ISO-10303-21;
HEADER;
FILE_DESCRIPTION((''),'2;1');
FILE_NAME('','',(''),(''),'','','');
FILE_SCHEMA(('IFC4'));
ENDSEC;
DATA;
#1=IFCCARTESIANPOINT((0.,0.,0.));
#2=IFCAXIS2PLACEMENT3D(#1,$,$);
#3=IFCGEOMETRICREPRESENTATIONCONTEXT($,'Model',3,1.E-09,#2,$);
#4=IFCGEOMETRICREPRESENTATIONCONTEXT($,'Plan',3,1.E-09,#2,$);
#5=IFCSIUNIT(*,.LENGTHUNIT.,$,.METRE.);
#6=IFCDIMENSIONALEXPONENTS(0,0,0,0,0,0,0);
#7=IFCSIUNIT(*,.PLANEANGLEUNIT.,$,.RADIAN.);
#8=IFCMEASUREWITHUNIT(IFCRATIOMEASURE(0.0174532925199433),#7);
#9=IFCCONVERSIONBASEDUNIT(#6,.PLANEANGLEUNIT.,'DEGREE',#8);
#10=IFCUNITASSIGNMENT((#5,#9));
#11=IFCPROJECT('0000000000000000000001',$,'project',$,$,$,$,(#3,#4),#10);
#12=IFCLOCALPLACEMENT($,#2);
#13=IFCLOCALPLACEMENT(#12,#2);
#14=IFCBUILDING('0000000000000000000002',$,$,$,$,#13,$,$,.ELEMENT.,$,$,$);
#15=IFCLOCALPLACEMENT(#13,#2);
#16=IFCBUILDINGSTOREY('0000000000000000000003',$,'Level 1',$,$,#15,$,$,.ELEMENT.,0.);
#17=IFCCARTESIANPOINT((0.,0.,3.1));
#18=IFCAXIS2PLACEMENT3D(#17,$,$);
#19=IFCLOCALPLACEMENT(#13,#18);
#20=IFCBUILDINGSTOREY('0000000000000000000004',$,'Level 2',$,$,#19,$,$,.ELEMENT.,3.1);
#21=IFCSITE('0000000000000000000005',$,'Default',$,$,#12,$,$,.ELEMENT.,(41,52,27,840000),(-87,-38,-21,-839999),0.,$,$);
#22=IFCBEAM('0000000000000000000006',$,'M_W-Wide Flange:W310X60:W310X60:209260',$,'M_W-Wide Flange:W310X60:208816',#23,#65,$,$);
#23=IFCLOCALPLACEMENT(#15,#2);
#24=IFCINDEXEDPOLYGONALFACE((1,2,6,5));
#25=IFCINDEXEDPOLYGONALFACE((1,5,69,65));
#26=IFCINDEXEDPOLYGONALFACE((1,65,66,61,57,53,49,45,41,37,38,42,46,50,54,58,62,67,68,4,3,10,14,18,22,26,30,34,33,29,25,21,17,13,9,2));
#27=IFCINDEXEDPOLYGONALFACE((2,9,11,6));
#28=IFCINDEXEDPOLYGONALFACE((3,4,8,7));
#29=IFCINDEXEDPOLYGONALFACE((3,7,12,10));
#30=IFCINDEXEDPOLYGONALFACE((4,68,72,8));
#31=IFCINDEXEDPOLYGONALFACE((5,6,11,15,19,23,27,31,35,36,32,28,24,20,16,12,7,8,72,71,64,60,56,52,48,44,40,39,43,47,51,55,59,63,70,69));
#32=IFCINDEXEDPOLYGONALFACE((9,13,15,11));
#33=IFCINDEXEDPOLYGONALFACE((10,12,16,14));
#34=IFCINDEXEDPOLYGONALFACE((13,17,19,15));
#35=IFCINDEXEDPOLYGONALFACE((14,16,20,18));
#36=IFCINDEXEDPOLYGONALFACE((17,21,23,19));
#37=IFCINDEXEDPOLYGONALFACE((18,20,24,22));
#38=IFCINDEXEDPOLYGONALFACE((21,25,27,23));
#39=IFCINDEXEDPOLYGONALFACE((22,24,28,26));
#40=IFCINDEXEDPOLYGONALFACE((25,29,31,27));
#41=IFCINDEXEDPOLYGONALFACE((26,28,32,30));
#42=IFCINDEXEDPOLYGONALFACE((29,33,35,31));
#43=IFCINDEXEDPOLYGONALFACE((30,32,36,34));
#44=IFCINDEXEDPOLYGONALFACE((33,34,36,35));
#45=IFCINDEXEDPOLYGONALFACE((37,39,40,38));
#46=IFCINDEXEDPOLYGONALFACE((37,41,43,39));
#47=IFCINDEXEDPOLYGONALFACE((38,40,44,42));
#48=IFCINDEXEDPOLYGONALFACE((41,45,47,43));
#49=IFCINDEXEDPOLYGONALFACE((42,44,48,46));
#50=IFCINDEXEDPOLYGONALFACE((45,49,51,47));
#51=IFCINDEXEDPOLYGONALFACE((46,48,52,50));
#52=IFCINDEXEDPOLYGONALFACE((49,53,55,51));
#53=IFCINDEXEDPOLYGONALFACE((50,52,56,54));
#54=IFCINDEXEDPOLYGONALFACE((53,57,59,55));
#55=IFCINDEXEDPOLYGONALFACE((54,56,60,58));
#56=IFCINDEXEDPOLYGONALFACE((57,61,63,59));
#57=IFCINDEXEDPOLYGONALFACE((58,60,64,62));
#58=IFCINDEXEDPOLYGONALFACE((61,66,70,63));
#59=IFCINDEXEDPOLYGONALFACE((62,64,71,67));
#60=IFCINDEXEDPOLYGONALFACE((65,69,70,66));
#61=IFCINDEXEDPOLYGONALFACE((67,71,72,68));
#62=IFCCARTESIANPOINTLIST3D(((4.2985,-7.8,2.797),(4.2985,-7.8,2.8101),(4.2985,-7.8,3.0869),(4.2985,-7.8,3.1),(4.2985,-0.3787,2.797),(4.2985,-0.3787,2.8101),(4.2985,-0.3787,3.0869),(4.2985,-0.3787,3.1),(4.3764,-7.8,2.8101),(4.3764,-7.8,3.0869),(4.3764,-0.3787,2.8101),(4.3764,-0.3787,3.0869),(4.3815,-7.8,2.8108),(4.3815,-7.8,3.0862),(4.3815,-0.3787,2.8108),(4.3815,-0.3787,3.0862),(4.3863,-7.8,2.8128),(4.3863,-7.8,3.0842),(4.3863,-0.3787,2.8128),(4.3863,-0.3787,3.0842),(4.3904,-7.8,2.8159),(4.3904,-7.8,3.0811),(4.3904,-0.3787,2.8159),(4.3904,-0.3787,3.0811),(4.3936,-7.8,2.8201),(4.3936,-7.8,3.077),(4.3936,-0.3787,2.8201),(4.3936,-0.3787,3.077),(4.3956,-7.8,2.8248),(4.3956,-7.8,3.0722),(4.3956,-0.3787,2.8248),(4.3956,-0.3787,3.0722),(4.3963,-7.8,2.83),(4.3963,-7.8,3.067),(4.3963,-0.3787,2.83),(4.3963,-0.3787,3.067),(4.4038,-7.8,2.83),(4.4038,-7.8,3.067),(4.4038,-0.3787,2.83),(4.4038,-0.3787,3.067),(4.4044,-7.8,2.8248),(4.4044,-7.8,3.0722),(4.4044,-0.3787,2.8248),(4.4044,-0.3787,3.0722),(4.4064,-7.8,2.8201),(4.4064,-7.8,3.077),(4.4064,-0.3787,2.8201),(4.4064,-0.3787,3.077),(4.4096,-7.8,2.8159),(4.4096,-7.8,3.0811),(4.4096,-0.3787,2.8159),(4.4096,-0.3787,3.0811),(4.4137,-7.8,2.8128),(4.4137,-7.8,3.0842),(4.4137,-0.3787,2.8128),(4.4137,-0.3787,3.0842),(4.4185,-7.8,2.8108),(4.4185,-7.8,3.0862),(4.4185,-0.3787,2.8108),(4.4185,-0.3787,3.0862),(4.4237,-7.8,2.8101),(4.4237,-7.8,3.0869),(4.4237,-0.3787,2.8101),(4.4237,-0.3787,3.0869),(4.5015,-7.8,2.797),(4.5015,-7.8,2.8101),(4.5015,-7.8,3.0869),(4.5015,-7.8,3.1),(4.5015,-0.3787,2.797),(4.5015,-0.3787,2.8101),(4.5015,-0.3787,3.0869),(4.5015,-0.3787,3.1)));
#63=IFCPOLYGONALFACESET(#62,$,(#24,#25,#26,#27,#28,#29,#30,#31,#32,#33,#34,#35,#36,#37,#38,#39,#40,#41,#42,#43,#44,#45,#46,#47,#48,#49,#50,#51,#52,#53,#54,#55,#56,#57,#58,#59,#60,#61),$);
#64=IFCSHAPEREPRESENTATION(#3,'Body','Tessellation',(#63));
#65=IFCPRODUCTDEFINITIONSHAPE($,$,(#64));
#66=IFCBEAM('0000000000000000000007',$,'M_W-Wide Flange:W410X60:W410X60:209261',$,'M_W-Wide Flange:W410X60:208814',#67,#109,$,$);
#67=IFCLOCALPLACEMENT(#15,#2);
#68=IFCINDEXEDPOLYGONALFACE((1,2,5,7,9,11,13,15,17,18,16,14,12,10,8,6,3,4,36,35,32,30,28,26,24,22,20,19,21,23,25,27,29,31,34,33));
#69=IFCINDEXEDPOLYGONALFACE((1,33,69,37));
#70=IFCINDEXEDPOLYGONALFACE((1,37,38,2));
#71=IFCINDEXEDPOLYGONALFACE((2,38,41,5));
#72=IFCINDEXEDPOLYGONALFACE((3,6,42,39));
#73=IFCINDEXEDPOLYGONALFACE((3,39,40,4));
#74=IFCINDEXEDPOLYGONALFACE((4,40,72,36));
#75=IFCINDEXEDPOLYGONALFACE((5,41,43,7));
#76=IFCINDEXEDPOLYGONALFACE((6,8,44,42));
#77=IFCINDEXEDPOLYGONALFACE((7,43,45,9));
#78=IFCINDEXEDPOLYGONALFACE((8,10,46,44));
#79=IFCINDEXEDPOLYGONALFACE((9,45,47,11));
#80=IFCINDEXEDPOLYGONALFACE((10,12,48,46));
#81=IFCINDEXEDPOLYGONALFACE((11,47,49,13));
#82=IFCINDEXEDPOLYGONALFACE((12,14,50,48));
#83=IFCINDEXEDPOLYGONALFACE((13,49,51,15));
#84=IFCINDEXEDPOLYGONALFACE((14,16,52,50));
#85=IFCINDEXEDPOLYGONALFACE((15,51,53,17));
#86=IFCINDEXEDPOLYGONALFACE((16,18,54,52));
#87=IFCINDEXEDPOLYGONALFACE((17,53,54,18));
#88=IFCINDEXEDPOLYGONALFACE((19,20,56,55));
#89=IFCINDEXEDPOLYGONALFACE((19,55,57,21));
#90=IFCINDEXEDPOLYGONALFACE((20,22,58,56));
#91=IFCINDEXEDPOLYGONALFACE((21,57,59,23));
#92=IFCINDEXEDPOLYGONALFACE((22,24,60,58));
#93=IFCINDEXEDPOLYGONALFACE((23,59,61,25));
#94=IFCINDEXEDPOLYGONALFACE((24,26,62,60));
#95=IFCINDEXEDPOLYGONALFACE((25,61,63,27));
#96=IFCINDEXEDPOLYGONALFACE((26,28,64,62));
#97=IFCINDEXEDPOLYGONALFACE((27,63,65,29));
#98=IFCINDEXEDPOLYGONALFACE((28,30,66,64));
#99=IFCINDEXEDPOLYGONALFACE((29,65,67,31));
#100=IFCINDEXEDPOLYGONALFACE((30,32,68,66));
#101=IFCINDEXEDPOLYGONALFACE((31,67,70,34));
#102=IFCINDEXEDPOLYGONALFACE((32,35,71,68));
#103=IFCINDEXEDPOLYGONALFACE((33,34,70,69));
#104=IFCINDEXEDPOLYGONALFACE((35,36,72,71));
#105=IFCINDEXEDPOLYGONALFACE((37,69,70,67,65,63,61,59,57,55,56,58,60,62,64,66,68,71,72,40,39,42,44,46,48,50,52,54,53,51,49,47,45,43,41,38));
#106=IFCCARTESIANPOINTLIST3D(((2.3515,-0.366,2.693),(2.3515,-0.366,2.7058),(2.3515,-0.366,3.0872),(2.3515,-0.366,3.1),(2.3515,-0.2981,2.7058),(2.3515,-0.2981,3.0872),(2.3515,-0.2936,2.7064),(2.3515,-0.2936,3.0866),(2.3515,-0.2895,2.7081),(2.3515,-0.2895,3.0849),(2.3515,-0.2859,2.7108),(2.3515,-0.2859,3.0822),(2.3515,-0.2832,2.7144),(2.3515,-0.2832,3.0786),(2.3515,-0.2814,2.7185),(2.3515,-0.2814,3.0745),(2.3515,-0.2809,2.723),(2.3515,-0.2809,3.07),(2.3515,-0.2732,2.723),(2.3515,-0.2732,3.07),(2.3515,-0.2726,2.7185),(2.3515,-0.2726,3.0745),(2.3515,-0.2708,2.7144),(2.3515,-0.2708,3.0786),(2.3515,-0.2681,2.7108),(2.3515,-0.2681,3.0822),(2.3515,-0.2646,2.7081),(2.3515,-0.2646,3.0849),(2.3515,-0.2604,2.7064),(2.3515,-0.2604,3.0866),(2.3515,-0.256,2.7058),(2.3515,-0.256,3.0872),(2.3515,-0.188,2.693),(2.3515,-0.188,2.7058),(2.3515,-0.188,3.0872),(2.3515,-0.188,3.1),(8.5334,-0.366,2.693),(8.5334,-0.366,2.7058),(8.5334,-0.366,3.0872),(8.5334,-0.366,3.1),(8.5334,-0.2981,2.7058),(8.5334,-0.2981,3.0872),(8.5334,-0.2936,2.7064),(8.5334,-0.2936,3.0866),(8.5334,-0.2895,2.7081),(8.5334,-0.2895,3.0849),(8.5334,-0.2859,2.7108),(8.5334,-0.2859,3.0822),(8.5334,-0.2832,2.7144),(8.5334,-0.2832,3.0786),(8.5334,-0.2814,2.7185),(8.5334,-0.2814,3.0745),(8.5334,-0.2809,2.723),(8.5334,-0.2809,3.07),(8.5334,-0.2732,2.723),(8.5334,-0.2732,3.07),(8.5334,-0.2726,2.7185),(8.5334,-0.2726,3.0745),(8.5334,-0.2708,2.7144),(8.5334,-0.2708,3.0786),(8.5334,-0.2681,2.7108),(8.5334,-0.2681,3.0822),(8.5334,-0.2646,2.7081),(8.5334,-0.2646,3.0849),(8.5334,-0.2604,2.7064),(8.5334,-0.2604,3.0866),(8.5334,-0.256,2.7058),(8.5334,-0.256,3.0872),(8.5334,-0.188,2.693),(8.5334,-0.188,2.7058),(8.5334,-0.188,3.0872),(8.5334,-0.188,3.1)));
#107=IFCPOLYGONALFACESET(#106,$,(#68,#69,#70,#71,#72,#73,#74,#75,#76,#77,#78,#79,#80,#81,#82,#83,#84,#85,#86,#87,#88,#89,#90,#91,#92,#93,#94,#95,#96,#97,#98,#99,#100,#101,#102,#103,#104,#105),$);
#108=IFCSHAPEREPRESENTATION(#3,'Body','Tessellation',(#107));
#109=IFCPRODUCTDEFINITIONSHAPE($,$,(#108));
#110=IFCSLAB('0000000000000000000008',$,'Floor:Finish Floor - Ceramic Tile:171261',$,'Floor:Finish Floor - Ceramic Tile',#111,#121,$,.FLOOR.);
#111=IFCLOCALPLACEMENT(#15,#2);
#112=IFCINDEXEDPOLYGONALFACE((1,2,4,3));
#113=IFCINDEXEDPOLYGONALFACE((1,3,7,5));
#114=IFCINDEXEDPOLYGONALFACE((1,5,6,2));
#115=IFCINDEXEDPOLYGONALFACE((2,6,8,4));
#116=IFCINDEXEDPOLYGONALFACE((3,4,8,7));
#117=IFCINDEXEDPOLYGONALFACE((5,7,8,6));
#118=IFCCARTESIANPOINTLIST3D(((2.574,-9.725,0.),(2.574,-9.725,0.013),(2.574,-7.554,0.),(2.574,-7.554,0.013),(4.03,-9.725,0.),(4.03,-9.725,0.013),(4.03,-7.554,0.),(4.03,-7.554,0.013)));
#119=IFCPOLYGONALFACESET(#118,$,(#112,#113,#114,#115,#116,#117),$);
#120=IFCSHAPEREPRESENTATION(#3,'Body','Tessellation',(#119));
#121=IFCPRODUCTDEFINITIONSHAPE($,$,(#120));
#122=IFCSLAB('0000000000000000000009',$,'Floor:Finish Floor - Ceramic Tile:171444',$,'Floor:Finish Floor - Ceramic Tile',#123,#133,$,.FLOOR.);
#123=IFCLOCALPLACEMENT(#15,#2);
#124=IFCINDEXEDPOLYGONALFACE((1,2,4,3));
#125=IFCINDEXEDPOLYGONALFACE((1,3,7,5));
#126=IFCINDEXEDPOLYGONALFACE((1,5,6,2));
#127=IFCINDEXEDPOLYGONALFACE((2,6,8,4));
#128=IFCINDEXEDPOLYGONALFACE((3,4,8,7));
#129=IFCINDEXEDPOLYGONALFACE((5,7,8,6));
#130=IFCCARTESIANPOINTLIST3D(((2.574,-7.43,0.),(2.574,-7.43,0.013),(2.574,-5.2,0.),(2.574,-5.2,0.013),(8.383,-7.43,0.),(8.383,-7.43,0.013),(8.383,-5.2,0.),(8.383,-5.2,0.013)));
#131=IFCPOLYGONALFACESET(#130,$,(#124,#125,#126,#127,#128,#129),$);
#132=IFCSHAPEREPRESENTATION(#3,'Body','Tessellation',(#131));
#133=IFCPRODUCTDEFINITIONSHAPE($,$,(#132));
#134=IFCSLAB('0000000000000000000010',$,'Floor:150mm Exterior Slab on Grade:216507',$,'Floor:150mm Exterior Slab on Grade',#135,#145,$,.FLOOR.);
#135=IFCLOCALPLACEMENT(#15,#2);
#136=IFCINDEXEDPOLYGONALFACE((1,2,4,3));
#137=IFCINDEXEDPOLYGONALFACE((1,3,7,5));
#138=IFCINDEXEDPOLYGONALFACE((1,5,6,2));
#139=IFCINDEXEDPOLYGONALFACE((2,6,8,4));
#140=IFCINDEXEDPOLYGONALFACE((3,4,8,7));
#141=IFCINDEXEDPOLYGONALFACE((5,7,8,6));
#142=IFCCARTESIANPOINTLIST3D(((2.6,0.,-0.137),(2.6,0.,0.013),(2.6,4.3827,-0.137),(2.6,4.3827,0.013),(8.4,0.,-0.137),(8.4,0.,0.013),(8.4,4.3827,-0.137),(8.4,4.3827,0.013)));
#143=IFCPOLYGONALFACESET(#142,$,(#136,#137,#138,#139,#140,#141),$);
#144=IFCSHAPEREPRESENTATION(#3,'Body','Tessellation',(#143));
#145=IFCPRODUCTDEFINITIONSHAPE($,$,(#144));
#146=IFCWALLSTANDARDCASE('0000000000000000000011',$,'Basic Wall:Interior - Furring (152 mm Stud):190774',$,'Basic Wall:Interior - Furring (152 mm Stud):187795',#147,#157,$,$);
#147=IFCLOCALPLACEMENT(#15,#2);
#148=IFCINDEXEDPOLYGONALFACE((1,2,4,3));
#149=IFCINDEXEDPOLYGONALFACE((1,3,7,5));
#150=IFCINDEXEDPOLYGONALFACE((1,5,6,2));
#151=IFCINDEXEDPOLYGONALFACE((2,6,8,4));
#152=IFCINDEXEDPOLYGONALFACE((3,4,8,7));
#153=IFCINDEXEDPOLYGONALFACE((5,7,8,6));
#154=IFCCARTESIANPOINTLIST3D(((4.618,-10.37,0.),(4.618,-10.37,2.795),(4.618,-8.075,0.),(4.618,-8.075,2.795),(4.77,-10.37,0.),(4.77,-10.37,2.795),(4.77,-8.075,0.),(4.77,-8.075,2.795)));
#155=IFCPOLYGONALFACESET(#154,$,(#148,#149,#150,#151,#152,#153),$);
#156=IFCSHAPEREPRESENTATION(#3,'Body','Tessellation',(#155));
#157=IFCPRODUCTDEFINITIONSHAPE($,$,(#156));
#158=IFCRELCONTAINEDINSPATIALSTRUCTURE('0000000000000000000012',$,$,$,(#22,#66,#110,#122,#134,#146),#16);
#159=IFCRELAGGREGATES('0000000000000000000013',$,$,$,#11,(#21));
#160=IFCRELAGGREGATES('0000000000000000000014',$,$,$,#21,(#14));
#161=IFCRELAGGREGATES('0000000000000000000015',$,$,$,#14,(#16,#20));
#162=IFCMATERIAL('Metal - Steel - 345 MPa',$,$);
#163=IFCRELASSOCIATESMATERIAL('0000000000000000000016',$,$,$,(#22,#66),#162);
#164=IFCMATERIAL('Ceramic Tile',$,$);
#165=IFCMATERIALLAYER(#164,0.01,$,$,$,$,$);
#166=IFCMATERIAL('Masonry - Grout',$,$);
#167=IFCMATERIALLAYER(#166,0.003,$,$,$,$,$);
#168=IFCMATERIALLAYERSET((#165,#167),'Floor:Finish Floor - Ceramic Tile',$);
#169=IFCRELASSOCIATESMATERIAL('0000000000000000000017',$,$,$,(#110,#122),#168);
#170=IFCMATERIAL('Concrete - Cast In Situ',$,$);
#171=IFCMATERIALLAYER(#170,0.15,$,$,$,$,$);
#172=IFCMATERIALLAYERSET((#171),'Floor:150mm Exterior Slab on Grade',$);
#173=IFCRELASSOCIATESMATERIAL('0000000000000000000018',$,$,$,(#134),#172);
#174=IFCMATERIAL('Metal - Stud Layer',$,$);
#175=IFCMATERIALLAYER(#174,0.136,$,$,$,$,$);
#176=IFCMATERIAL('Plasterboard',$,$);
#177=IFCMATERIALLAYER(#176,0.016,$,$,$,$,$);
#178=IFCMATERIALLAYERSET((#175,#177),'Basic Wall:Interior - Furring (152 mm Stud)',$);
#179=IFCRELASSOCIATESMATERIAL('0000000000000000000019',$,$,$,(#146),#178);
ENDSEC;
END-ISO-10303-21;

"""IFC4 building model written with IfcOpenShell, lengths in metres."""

from ifc_helpers import new_model, entity, si_unit, converted_unit, frame, frame_2d, origin, place, context, project, spatial, polyline, circle_curve, parameter, trimmed, segment, composite_curve, rectangle, outline, extrude, material, layer, layer_set, layer_usage, element, save


model = new_model("IFC4")

# Units and contexts
model_context = context("Model", 3, precision=1e-09, world=origin())
plan_context = context("Plan", 3, precision=1e-09, world=origin())
ifc_project = project(units=[si_unit("LENGTHUNIT", "METRE"), converted_unit("PLANEANGLEUNIT", "DEGREE", entity("IfcRatioMeasure", 0.0174532925199433), si_unit("PLANEANGLEUNIT", "RADIAN"), dimensions=[0, 0, 0, 0, 0, 0, 0])], contexts=[model_context, plan_context])

# Site, building, storey
site_placement = place(None, origin())
site = spatial("IfcSite", under=ifc_project, at=site_placement, Name="Default", CompositionType="ELEMENT", RefLatitude=(41, 52, 27, 840000), RefLongitude=(-87, -38, -21, -839999), RefElevation=0.0)
building_placement = place(site_placement, origin())
building = spatial("IfcBuilding", under=site, at=building_placement, CompositionType="ELEMENT")
storey_1_placement = place(building_placement, origin())
storey_1 = spatial("IfcBuildingStorey", under=building, at=storey_1_placement, Name="Level 1", CompositionType="ELEMENT", Elevation=0.0)

# Beams
ifc_material_1 = material(Name="Metal - Steel - 345 MPa")
beam_1_placement = place(storey_1_placement, frame((4.4, -7.8, 3.1)))
element("IfcBeam", 1, at=beam_1_placement, inside=storey_1, material=ifc_material_1, Name="M_W-Wide Flange:W310X60:W310X60:209260", ObjectType="M_W-Wide Flange:W310X60:208816", context=model_context, shape_type="SweptSolid", body=[
    extrude(outline(composite_curve([segment(polyline([(-0.1015, -0.1384), (-0.1015, -0.1515)]), True, "CONTINUOUS"), segment(polyline([(-0.1015, -0.1515), (0.1015, -0.1515)]), True, "CONTINUOUS"), segment(polyline([(0.1015, -0.1515), (0.1015, -0.1384)]), True, "CONTINUOUS"), segment(polyline([(0.1015, -0.1384), (0.0236, -0.1384)]), True, "CONTINUOUS"), segment(trimmed(circle_curve(frame_2d((0.0236, -0.1185), x_axis=(1.0, 0.0)), 0.0199), [parameter(180.0)], [parameter(270.0)], True, "PARAMETER"), False, "CONTINUOUS"), segment(polyline([(0.0037, -0.1185), (0.0037, 0.1185)]), True, "CONTINUOUS"), segment(trimmed(circle_curve(frame_2d((0.0236, 0.1185), x_axis=(1.0, 0.0)), 0.0199), [parameter(90.0)], [parameter(180.0)], True, "PARAMETER"), False, "CONTINUOUS"), segment(polyline([(0.0236, 0.1384), (0.1015, 0.1384)]), True, "CONTINUOUS"), segment(polyline([(0.1015, 0.1384), (0.1015, 0.1515)]), True, "CONTINUOUS"), segment(polyline([(0.1015, 0.1515), (-0.1015, 0.1515)]), True, "CONTINUOUS"), segment(polyline([(-0.1015, 0.1515), (-0.1015, 0.1384)]), True, "CONTINUOUS"), segment(polyline([(-0.1015, 0.1384), (-0.0237, 0.1384)]), True, "CONTINUOUS"), segment(trimmed(circle_curve(frame_2d((-0.0237, 0.1185), x_axis=(1.0, 0.0)), 0.0199), [parameter(360.0)], [parameter(90.0)], True, "PARAMETER"), False, "CONTINUOUS"), segment(polyline([(-0.0038, 0.1185), (-0.0038, -0.1185)]), True, "CONTINUOUS"), segment(trimmed(circle_curve(frame_2d((-0.0237, -0.1185), x_axis=(1.0, 0.0)), 0.0199), [parameter(270.0)], [parameter(0.0)], True, "PARAMETER"), False, "CONTINUOUS"), segment(polyline([(-0.0237, -0.1384), (-0.1015, -0.1384)]), True, "CONTINUOUS")], self_intersect=False)), frame((0.0, 0.0, -0.1515), z_axis=(0.0, -1.0, 0.0), x_axis=(1.0, 0.0, 0.0)), (0.0, 0.0, -1.0), 7.4213),
])
beam_2_placement = place(storey_1_placement, frame((8.5915, -0.277, 3.1), z_axis=(0.0, 0.0, 1.0), x_axis=(0.0, 1.0, 0.0)))
element("IfcBeam", 2, at=beam_2_placement, inside=storey_1, material=ifc_material_1, Name="M_W-Wide Flange:W410X60:W410X60:209261", ObjectType="M_W-Wide Flange:W410X60:208814", context=model_context, shape_type="SweptSolid", body=[
    extrude(outline(composite_curve([segment(polyline([(0.1907, -0.089), (0.2035, -0.089)]), True, "CONTINUOUS"), segment(polyline([(0.2035, -0.089), (0.2035, 0.089)]), True, "CONTINUOUS"), segment(polyline([(0.2035, 0.089), (0.1907, 0.089)]), True, "CONTINUOUS"), segment(polyline([(0.1907, 0.089), (0.1907, 0.021)]), True, "CONTINUOUS"), segment(trimmed(circle_curve(frame_2d((0.1735, 0.021), x_axis=(1.0, 0.0)), 0.0172), [parameter(270.0)], [parameter(360.0)], True, "PARAMETER"), False, "CONTINUOUS"), segment(polyline([(0.1735, 0.0038), (-0.1735, 0.0038)]), True, "CONTINUOUS"), segment(trimmed(circle_curve(frame_2d((-0.1735, 0.021), x_axis=(0.0, -1.0)), 0.0172), [parameter(270.0)], [parameter(360.0)], True, "PARAMETER"), False, "CONTINUOUS"), segment(polyline([(-0.1907, 0.021), (-0.1907, 0.089)]), True, "CONTINUOUS"), segment(polyline([(-0.1907, 0.089), (-0.2035, 0.089)]), True, "CONTINUOUS"), segment(polyline([(-0.2035, 0.089), (-0.2035, -0.089)]), True, "CONTINUOUS"), segment(polyline([(-0.2035, -0.089), (-0.1907, -0.089)]), True, "CONTINUOUS"), segment(polyline([(-0.1907, -0.089), (-0.1907, -0.0211)]), True, "CONTINUOUS"), segment(trimmed(circle_curve(frame_2d((-0.1735, -0.0211), x_axis=(-1.0, 0.0)), 0.0172), [parameter(270.0)], [parameter(0.0)], True, "PARAMETER"), False, "CONTINUOUS"), segment(polyline([(-0.1735, -0.0039), (0.1735, -0.0039)]), True, "CONTINUOUS"), segment(trimmed(circle_curve(frame_2d((0.1735, -0.0211), x_axis=(0.0, 1.0)), 0.0172), [parameter(270.0)], [parameter(0.0)], True, "PARAMETER"), False, "CONTINUOUS"), segment(polyline([(0.1907, -0.0211), (0.1907, -0.089)]), True, "CONTINUOUS")], self_intersect=False)), frame((0.0, 6.24, -0.2035), z_axis=(0.0, -1.0, 0.0), x_axis=(0.0, 0.0, -1.0)), (0.0, 0.0, 1.0), 6.1819),
])

# Slabs
ifc_material_2 = material(Name="Ceramic Tile")
ifc_layer_1 = layer(ifc_material_2, 0.01)
ifc_material_3 = material(Name="Masonry - Grout")
ifc_layer_2 = layer(ifc_material_3, 0.003)
ifc_layer_set_1 = layer_set([ifc_layer_1, ifc_layer_2], Name="Floor:Finish Floor - Ceramic Tile")
ifc_layer_usage_1 = layer_usage(ifc_layer_set_1, "AXIS3", "POSITIVE", 0.0)
slab_1_placement = place(storey_1_placement, frame((2.574, -9.725, 0.0)))
element("IfcSlab", 3, at=slab_1_placement, inside=storey_1, material=ifc_layer_usage_1, Name="Floor:Finish Floor - Ceramic Tile:171261", ObjectType="Floor:Finish Floor - Ceramic Tile", PredefinedType="FLOOR", context=model_context, shape_type="SweptSolid", body=[
    extrude(rectangle(XDim=2.171, YDim=1.456, at=frame_2d((0.0, 0.0), x_axis=(0.0, -1.0))), frame((0.728, 1.0855, 0.013), z_axis=(0.0, 0.0, -1.0), x_axis=(-1.0, 0.0, 0.0)), (0.0, 0.0, 1.0), 0.013),
])
ifc_layer_usage_2 = layer_usage(ifc_layer_set_1, "AXIS3", "POSITIVE", 0.0)
slab_2_placement = place(storey_1_placement, frame((2.574, -7.43, 0.0)))
element("IfcSlab", 4, at=slab_2_placement, inside=storey_1, material=ifc_layer_usage_2, Name="Floor:Finish Floor - Ceramic Tile:171444", ObjectType="Floor:Finish Floor - Ceramic Tile", PredefinedType="FLOOR", context=model_context, shape_type="SweptSolid", body=[
    extrude(rectangle(XDim=5.809, YDim=2.23, at=frame_2d((0.0, 0.0), x_axis=(-1.0, 0.0))), frame((2.9045, 1.115, 0.013), z_axis=(0.0, 0.0, -1.0), x_axis=(-1.0, 0.0, 0.0)), (0.0, 0.0, 1.0), 0.013),
])
ifc_material_4 = material(Name="Concrete - Cast In Situ")
ifc_layer_3 = layer(ifc_material_4, 0.15)
ifc_layer_set_2 = layer_set([ifc_layer_3], Name="Floor:150mm Exterior Slab on Grade")
ifc_layer_usage_3 = layer_usage(ifc_layer_set_2, "AXIS3", "POSITIVE", 0.0)
slab_3_placement = place(storey_1_placement, frame((2.6, 0.0, -0.137)))
element("IfcSlab", 5, at=slab_3_placement, inside=storey_1, material=ifc_layer_usage_3, Name="Floor:150mm Exterior Slab on Grade:216507", ObjectType="Floor:150mm Exterior Slab on Grade", PredefinedType="FLOOR", context=model_context, shape_type="SweptSolid", body=[
    extrude(rectangle(XDim=5.8, YDim=4.3827, at=frame_2d((0.0, 0.0), x_axis=(-1.0, 0.0))), frame((2.9, 2.1914, 0.15), z_axis=(0.0, 0.0, -1.0), x_axis=(-1.0, 0.0, 0.0)), (0.0, 0.0, 1.0), 0.15),
])

# Wall
ifc_material_5 = material(Name="Metal - Stud Layer")
ifc_layer_4 = layer(ifc_material_5, 0.136)
ifc_material_6 = material(Name="Plasterboard")
ifc_layer_5 = layer(ifc_material_6, 0.016)
ifc_layer_set_3 = layer_set([ifc_layer_4, ifc_layer_5], Name="Basic Wall:Interior - Furring (152 mm Stud)")
ifc_layer_usage_4 = layer_usage(ifc_layer_set_3, "AXIS2", "POSITIVE", -0.076)
wall_1_placement = place(storey_1_placement, frame((4.694, -8.075, 0.0), z_axis=(0.0, 0.0, 1.0), x_axis=(0.0, -1.0, 0.0)))
element("IfcWallStandardCase", 6, at=wall_1_placement, inside=storey_1, material=ifc_layer_usage_4, Name="Basic Wall:Interior - Furring (152 mm Stud):190774", ObjectType="Basic Wall:Interior - Furring (152 mm Stud):187795", context=model_context, shape_type="SweptSolid", body=[
    extrude(rectangle(XDim=2.295, YDim=0.152, at=frame_2d((1.1475, 0.0), x_axis=(-1.0, 0.0))), origin(), (0.0, 0.0, 1.0), 2.795),
])

# Shared definitions
storey_2_placement = place(building_placement, frame((0.0, 0.0, 3.1)))
storey_2 = spatial("IfcBuildingStorey", under=building, at=storey_2_placement, Name="Level 2", CompositionType="ELEMENT", Elevation=3.1)

save(model, "model.ifc")
